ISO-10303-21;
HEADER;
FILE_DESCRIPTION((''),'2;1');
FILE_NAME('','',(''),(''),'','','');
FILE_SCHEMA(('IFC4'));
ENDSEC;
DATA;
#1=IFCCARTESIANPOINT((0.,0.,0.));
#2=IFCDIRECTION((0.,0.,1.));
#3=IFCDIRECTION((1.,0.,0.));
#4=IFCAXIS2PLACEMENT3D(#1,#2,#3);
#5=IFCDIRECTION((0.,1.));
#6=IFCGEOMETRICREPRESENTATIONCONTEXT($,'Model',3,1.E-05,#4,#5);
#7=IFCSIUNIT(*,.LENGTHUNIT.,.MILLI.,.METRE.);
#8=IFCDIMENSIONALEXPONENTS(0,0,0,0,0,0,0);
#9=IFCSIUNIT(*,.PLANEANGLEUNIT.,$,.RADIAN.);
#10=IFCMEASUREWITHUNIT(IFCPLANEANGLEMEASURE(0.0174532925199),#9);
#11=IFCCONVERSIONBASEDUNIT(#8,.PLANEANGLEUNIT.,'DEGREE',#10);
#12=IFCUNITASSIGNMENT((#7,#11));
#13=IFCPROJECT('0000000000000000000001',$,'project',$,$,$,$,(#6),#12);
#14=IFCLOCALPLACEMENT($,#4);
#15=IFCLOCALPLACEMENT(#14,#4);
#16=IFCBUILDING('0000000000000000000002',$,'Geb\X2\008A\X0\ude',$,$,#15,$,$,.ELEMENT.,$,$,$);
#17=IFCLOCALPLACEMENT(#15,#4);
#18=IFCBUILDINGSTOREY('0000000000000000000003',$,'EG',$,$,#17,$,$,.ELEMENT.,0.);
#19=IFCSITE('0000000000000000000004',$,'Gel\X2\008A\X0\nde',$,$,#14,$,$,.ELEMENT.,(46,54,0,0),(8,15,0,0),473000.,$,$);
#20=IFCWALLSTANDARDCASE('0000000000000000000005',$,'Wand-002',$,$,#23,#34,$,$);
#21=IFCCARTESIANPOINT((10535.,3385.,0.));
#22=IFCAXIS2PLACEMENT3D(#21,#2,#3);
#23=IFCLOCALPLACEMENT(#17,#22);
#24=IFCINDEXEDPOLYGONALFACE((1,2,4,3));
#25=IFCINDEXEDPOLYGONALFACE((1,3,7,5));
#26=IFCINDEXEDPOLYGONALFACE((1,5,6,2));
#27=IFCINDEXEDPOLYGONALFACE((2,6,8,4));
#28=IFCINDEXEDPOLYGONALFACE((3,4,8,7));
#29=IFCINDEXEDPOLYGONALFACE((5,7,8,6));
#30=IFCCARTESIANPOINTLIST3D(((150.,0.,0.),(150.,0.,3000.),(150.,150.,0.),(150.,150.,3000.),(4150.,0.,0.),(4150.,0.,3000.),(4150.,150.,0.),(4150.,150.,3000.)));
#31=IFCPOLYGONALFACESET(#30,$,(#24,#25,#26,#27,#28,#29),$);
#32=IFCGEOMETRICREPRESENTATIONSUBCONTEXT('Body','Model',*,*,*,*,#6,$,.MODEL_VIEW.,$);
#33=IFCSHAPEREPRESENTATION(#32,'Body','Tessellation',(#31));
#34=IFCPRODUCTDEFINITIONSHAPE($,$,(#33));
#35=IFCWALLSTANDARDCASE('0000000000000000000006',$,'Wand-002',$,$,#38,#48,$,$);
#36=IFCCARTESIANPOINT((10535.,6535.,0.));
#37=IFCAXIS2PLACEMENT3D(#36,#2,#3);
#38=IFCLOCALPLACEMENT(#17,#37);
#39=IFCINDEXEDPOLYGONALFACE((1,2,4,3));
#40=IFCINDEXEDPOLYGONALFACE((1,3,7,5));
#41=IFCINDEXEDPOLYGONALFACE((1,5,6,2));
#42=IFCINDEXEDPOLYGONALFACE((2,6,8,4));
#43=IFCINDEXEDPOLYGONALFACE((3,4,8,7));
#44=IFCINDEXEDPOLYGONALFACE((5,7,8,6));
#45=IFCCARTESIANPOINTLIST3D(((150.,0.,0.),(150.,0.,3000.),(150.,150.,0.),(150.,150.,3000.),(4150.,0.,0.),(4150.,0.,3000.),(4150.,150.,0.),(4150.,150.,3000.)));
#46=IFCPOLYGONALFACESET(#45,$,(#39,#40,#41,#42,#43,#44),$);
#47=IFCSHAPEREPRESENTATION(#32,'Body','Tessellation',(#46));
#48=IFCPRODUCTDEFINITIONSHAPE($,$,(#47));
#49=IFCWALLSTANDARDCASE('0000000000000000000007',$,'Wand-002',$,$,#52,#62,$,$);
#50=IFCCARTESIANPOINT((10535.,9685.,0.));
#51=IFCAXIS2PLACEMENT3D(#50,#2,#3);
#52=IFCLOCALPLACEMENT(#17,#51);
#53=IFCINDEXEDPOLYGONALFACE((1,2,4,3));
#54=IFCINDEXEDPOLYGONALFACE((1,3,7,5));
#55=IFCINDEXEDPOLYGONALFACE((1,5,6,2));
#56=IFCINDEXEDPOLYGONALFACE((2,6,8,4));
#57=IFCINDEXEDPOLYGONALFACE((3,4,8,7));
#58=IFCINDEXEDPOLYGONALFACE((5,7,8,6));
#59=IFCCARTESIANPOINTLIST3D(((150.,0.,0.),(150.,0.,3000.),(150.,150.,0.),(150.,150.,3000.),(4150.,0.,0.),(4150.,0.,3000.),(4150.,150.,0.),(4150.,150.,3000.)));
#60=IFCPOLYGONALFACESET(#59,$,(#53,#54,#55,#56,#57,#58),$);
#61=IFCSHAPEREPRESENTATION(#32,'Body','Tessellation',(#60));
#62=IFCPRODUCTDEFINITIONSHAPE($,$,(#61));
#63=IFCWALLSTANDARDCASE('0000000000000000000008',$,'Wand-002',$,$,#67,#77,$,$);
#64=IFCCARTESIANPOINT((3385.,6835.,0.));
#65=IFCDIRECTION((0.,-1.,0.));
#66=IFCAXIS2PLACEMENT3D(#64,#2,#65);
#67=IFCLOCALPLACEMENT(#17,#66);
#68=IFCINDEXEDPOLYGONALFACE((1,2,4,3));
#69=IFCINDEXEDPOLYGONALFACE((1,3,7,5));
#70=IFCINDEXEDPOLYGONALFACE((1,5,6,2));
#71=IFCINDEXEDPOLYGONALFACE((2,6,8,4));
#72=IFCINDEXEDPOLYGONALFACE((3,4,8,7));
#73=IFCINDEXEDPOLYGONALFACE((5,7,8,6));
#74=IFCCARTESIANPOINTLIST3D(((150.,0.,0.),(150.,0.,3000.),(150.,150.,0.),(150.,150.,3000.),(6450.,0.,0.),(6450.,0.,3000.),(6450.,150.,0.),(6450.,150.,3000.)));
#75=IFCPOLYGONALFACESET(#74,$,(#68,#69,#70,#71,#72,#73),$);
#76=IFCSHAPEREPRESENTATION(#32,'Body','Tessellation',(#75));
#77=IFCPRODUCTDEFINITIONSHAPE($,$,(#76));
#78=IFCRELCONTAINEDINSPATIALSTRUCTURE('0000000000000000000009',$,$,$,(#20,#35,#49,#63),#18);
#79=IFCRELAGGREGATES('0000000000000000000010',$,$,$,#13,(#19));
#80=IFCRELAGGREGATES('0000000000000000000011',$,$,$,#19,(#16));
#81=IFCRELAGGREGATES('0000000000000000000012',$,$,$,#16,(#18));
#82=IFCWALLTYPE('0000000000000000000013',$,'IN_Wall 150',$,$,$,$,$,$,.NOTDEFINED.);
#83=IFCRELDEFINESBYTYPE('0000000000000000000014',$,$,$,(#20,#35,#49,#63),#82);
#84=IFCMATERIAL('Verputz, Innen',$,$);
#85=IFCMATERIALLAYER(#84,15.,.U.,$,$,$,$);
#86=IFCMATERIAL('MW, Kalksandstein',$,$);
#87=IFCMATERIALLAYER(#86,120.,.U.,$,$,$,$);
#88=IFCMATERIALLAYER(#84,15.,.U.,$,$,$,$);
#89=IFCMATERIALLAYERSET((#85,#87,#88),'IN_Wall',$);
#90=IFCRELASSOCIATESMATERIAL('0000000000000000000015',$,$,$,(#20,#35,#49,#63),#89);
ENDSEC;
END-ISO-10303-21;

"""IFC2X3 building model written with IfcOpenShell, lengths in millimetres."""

from ifc_helpers import new_model, entity, si_unit, converted_unit, direction, frame, origin_with_axes, place, context, subcontext, project, spatial, polyline, outline, extrude, material, layer, layer_set, layer_usage, type_object, element, save


model = new_model("IFC2X3")

# Units and contexts
model_context = context("Model", 3, precision=1e-05, world=origin_with_axes(), true_north=direction((0.0, 1.0)))
body_context = subcontext(model_context, "Body", "Model", "MODEL_VIEW")
ifc_project = project(units=[si_unit("LENGTHUNIT", "METRE", prefix="MILLI"), converted_unit("PLANEANGLEUNIT", "DEGREE", entity("IfcPlaneAngleMeasure", 0.0174532925199), si_unit("PLANEANGLEUNIT", "RADIAN"), dimensions=[0, 0, 0, 0, 0, 0, 0])], contexts=[model_context])

# Site, building, storey
site_placement = place(None, origin_with_axes())
site = spatial("IfcSite", under=ifc_project, at=site_placement, Name="Gel\u008ande", CompositionType="ELEMENT", RefLatitude=(46, 54, 0, 0), RefLongitude=(8, 15, 0, 0), RefElevation=473000.0)
building_placement = place(site_placement, origin_with_axes())
building = spatial("IfcBuilding", under=site, at=building_placement, Name="Geb\u008aude", CompositionType="ELEMENT")
storey_placement = place(building_placement, origin_with_axes())
storey = spatial("IfcBuildingStorey", under=building, at=storey_placement, Name="EG", CompositionType="ELEMENT", Elevation=0.0)

# Walls
ifc_material_1 = material(Name="Verputz, Innen")
ifc_layer_1 = layer(ifc_material_1, 15.0, ventilated="UNKNOWN")
ifc_material_2 = material(Name="MW, Kalksandstein")
ifc_layer_2 = layer(ifc_material_2, 120.0, ventilated="UNKNOWN")
ifc_layer_3 = layer(ifc_material_1, 15.0, ventilated="UNKNOWN")
ifc_layer_set_1 = layer_set([ifc_layer_1, ifc_layer_2, ifc_layer_3], Name="IN_Wall")
ifc_layer_usage_1 = layer_usage(ifc_layer_set_1, "AXIS2", "POSITIVE", 0.0)
wall_type_1 = type_object("IfcWallType", Name="IN_Wall 150", PredefinedType="NOTDEFINED")
wall_1_placement = place(storey_placement, frame((10535.0, 3385.0, 0.0), z_axis=(0.0, 0.0, 1.0), x_axis=(1.0, 0.0, 0.0)))
element("IfcWallStandardCase", 1, at=wall_1_placement, inside=storey, type_object=wall_type_1, material=ifc_layer_usage_1, Name="Wand-002", context=body_context, shape_type="SweptSolid", body=[
    extrude(outline(polyline([(150.0, 0.0), (4150.0, 0.0), (4150.0, 150.0), (150.0, 150.0), (150.0, 0.0)])), origin_with_axes(), (0.0, 0.0, 1.0), 3000.0),
])
ifc_layer_usage_2 = layer_usage(ifc_layer_set_1, "AXIS2", "POSITIVE", 0.0)
wall_2_placement = place(storey_placement, frame((10535.0, 6535.0, 0.0), z_axis=(0.0, 0.0, 1.0), x_axis=(1.0, 0.0, 0.0)))
element("IfcWallStandardCase", 2, at=wall_2_placement, inside=storey, type_object=wall_type_1, material=ifc_layer_usage_2, Name="Wand-002", context=body_context, shape_type="SweptSolid", body=[
    extrude(outline(polyline([(150.0, 0.0), (4150.0, 0.0), (4150.0, 150.0), (150.0, 150.0), (150.0, 0.0)])), origin_with_axes(), (0.0, 0.0, 1.0), 3000.0),
])
ifc_layer_usage_3 = layer_usage(ifc_layer_set_1, "AXIS2", "POSITIVE", 0.0)
wall_3_placement = place(storey_placement, frame((10535.0, 9685.0, 0.0), z_axis=(0.0, 0.0, 1.0), x_axis=(1.0, 0.0, 0.0)))
element("IfcWallStandardCase", 3, at=wall_3_placement, inside=storey, type_object=wall_type_1, material=ifc_layer_usage_3, Name="Wand-002", context=body_context, shape_type="SweptSolid", body=[
    extrude(outline(polyline([(150.0, 0.0), (4150.0, 0.0), (4150.0, 150.0), (150.0, 150.0), (150.0, 0.0)])), origin_with_axes(), (0.0, 0.0, 1.0), 3000.0),
])

# Wall
ifc_layer_usage_4 = layer_usage(ifc_layer_set_1, "AXIS2", "POSITIVE", 0.0)
wall_4_placement = place(storey_placement, frame((3385.0, 6835.0, 0.0), z_axis=(0.0, 0.0, 1.0), x_axis=(0.0, -1.0, 0.0)))
element("IfcWallStandardCase", 4, at=wall_4_placement, inside=storey, type_object=wall_type_1, material=ifc_layer_usage_4, Name="Wand-002", context=body_context, shape_type="SweptSolid", body=[
    extrude(outline(polyline([(150.0, 0.0), (6450.0, 0.0), (6450.0, 150.0), (150.0, 150.0), (150.0, 0.0)])), origin_with_axes(), (0.0, 0.0, 1.0), 3000.0),
])

save(model, "model.ifc")
